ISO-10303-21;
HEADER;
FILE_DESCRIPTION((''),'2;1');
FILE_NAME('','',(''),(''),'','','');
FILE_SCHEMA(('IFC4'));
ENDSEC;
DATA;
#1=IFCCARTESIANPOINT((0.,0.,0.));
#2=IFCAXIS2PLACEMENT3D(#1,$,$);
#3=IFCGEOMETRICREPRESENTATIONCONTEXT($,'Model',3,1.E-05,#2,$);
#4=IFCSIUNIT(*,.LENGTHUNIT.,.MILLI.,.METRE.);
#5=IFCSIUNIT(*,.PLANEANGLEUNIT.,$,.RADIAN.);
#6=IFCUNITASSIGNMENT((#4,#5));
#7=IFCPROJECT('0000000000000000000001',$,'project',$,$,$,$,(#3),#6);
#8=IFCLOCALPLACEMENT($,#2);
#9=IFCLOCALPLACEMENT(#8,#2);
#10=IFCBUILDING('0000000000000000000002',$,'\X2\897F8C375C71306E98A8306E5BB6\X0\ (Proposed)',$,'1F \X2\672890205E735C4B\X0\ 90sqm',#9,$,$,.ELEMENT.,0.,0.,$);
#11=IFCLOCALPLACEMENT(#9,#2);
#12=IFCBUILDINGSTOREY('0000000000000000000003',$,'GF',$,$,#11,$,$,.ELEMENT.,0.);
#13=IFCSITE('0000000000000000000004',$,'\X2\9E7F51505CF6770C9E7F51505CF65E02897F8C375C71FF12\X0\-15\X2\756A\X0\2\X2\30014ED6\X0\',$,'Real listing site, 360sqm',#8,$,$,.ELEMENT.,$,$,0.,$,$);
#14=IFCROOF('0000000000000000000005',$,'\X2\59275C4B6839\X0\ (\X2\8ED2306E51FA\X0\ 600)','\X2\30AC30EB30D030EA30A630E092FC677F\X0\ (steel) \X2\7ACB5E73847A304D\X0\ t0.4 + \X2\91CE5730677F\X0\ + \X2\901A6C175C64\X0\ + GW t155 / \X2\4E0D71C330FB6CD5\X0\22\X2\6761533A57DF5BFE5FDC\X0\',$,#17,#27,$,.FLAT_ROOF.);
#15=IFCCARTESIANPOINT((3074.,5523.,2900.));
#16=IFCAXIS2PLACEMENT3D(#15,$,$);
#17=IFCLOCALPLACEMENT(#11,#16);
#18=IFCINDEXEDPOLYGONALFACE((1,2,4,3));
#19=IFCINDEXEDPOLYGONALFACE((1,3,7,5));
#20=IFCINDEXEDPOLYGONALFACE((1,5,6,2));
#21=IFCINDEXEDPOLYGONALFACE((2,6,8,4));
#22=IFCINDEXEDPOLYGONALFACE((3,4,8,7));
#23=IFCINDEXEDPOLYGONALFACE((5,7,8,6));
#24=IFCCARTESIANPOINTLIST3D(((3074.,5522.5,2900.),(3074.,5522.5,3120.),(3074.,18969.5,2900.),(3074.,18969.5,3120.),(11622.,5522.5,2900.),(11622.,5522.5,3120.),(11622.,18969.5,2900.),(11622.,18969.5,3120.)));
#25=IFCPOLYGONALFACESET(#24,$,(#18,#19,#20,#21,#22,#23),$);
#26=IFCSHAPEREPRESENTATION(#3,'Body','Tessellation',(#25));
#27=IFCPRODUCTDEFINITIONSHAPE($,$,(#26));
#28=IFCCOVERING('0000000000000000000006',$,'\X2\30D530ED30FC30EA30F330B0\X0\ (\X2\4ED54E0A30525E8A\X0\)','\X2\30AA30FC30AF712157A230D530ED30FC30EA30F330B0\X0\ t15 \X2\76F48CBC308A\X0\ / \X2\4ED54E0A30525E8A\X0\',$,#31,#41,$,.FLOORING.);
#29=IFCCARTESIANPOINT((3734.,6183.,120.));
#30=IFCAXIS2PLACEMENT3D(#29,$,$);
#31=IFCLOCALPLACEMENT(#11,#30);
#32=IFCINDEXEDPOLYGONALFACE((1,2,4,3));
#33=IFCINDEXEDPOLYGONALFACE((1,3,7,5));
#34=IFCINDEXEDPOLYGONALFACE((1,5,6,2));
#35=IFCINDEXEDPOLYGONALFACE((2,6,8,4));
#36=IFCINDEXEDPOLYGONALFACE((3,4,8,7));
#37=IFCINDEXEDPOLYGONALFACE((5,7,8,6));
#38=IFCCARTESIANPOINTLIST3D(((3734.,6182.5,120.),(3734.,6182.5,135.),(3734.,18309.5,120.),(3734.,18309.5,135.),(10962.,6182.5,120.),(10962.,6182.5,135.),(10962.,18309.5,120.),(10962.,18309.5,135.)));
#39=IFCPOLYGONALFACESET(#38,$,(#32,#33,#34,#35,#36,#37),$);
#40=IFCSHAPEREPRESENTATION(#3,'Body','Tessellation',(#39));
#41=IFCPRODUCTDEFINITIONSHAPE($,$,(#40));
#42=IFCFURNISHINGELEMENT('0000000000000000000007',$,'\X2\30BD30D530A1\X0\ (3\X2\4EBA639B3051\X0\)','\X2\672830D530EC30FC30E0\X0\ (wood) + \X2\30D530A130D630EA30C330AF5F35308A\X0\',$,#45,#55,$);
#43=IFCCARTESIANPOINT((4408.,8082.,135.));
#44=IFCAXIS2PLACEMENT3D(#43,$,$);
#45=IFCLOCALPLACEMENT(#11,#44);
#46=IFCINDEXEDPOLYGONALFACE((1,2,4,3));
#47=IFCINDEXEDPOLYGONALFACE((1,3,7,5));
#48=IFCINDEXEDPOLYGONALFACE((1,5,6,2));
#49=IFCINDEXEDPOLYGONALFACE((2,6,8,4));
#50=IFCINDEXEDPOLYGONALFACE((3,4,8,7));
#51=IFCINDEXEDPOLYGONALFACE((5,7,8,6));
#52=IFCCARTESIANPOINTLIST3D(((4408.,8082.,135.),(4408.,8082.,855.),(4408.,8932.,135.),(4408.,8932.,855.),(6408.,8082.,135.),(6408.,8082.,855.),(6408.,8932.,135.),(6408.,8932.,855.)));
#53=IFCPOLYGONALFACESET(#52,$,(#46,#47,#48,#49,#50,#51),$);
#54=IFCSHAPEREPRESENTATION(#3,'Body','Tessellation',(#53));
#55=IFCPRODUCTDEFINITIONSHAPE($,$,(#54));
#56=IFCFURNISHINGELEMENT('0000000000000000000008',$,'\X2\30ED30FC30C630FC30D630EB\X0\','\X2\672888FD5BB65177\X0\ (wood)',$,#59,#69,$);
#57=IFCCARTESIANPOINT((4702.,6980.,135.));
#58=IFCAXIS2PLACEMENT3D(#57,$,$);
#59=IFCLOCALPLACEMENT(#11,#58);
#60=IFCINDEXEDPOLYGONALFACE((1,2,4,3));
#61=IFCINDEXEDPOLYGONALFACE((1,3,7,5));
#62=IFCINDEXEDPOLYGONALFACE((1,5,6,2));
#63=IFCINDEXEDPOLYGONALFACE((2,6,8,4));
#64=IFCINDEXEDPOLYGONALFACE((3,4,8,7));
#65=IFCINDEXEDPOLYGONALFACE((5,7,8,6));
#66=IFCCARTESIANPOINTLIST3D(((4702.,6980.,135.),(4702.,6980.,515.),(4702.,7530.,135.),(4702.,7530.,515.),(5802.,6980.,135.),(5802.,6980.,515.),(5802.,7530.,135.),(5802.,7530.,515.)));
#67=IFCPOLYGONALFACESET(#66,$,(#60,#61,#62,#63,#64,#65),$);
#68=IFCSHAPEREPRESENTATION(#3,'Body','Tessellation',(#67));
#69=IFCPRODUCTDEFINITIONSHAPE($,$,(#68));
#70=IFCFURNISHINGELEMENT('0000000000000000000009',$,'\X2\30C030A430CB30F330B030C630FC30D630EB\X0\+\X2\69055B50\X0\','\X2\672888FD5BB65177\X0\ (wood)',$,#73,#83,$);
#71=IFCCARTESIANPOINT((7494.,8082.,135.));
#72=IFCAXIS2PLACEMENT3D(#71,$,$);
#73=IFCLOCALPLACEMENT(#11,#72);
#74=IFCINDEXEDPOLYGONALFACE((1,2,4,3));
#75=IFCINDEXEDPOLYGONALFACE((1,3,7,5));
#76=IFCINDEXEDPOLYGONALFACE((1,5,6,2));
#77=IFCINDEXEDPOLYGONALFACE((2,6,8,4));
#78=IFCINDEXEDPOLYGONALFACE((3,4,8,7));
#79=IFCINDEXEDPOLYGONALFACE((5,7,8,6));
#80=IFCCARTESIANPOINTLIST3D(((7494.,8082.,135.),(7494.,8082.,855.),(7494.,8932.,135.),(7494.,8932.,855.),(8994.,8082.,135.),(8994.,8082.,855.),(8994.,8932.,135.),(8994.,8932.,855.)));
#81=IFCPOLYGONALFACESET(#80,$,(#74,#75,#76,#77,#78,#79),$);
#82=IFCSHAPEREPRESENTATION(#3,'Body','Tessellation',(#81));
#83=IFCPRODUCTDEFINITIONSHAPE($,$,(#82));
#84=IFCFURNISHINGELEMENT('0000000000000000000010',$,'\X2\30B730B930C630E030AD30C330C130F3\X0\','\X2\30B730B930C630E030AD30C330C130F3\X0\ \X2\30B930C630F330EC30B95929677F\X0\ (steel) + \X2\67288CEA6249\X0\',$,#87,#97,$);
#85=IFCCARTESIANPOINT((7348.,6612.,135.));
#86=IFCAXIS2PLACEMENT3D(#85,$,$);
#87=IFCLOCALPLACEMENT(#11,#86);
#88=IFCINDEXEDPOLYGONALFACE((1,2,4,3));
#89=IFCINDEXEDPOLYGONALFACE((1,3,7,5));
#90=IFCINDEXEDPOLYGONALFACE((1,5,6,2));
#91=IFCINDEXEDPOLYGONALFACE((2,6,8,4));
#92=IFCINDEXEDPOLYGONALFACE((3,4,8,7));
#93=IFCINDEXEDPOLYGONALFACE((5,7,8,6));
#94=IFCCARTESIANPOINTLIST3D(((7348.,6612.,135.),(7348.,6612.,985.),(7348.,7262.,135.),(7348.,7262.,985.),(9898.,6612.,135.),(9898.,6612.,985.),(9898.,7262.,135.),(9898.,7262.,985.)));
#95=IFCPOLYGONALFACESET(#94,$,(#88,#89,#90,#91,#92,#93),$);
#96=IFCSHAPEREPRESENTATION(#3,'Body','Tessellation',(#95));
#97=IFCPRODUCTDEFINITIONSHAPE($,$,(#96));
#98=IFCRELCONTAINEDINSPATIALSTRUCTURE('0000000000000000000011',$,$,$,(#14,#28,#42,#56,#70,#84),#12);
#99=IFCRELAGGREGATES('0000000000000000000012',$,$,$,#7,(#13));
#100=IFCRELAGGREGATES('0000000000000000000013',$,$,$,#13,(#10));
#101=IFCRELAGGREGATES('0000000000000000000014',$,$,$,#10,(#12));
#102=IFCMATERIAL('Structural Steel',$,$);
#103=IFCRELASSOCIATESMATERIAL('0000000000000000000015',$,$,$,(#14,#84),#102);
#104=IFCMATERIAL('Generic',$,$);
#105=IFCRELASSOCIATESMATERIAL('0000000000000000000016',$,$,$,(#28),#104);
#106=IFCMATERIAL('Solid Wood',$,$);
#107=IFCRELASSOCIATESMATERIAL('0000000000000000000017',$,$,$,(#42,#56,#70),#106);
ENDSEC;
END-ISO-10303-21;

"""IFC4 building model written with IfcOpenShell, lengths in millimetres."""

from ifc_helpers import new_model, si_unit, frame, frame_2d, origin, place, context, project, spatial, rectangle, extrude, material, element, save


model = new_model("IFC4")

# Units and contexts
model_context = context("Model", 3, precision=1e-05, world=origin())
ifc_project = project(units=[si_unit("LENGTHUNIT", "METRE", prefix="MILLI"), si_unit("PLANEANGLEUNIT", "RADIAN")], contexts=[model_context])

# Site, building, storey
site_placement = place(None, origin())
site = spatial("IfcSite", under=ifc_project, at=site_placement, Name="鹿児島県鹿児島市西谷山２-15番2、他", ObjectType="Real listing site, 360sqm", CompositionType="ELEMENT", RefElevation=0.0)
building_placement = place(site_placement, origin())
building = spatial("IfcBuilding", under=site, at=building_placement, Name="西谷山の風の家 (Proposed)", ObjectType="1F 木造平屋 90sqm", CompositionType="ELEMENT", ElevationOfRefHeight=0.0, ElevationOfTerrain=0.0)
storey_placement = place(building_placement, origin())
storey = spatial("IfcBuildingStorey", under=building, at=storey_placement, Name="GF", CompositionType="ELEMENT", Elevation=0.0)

# Shared definitions
ifc_material_1 = material(Name="Solid Wood")

# Roof
ifc_material_2 = material(Name="Structural Steel")
roof_placement = place(storey_placement, frame((3074.0, 5523.0, 2900.0)))
element("IfcRoof", 1, at=roof_placement, inside=storey, material=ifc_material_2, Name="大屋根 (軒の出 600)", Description="ガルバリウム鋼板 (steel) 立平葺き t0.4 + 野地板 + 通気層 + GW t155 / 不燃・法22条区域対応", PredefinedType="FLAT_ROOF", context=model_context, shape_type="SweptSolid", body=[
    extrude(rectangle(XDim=8548.0, YDim=13447.0, at=frame_2d((4274.0, 6723.0))), frame((3074.0, 5523.0, 2900.0)), (0.0, 0.0, 1.0), 220.0),
])

# Covering
ifc_material_3 = material(Name="Generic")
covering_placement = place(storey_placement, frame((3734.0, 6183.0, 120.0)))
element("IfcCovering", 2, at=covering_placement, inside=storey, material=ifc_material_3, Name="フローリング (仕上げ床)", Description="オーク無垢フローリング t15 直貼り / 仕上げ床", PredefinedType="FLOORING", context=model_context, shape_type="SweptSolid", body=[
    extrude(rectangle(XDim=7228.0, YDim=12127.0, at=frame_2d((3614.0, 6063.0))), frame((3734.0, 6183.0, 120.0)), (0.0, 0.0, 1.0), 15.0),
])

# Furnishing elements
furnishing_1_placement = place(storey_placement, frame((4408.0, 8082.0, 135.0)))
element("IfcFurnishingElement", 3, at=furnishing_1_placement, inside=storey, material=ifc_material_1, Name="ソファ (3人掛け)", Description="木フレーム (wood) + ファブリック張り", context=model_context, shape_type="SweptSolid", body=[
    extrude(rectangle(XDim=2000.0, YDim=850.0, at=frame_2d((1000.0, 425.0))), frame((4408.0, 8082.0, 135.0)), (0.0, 0.0, 1.0), 720.0),
])
furnishing_2_placement = place(storey_placement, frame((4702.0, 6980.0, 135.0)))
element("IfcFurnishingElement", 4, at=furnishing_2_placement, inside=storey, material=ifc_material_1, Name="ローテーブル", Description="木製家具 (wood)", context=model_context, shape_type="SweptSolid", body=[
    extrude(rectangle(XDim=1100.0, YDim=550.0, at=frame_2d((550.0, 275.0))), frame((4702.0, 6980.0, 135.0)), (0.0, 0.0, 1.0), 380.0),
])
furnishing_3_placement = place(storey_placement, frame((7494.0, 8082.0, 135.0)))
element("IfcFurnishingElement", 5, at=furnishing_3_placement, inside=storey, material=ifc_material_1, Name="ダイニングテーブル+椅子", Description="木製家具 (wood)", context=model_context, shape_type="SweptSolid", body=[
    extrude(rectangle(XDim=1500.0, YDim=850.0, at=frame_2d((750.0, 425.0))), frame((7494.0, 8082.0, 135.0)), (0.0, 0.0, 1.0), 720.0),
])
furnishing_4_placement = place(storey_placement, frame((7348.0, 6612.0, 135.0)))
element("IfcFurnishingElement", 6, at=furnishing_4_placement, inside=storey, material=ifc_material_2, Name="システムキッチン", Description="システムキッチン ステンレス天板 (steel) + 木質扉", context=model_context, shape_type="SweptSolid", body=[
    extrude(rectangle(XDim=2550.0, YDim=650.0, at=frame_2d((1275.0, 325.0))), frame((7348.0, 6612.0, 135.0)), (0.0, 0.0, 1.0), 850.0),
])

save(model, "model.ifc")
